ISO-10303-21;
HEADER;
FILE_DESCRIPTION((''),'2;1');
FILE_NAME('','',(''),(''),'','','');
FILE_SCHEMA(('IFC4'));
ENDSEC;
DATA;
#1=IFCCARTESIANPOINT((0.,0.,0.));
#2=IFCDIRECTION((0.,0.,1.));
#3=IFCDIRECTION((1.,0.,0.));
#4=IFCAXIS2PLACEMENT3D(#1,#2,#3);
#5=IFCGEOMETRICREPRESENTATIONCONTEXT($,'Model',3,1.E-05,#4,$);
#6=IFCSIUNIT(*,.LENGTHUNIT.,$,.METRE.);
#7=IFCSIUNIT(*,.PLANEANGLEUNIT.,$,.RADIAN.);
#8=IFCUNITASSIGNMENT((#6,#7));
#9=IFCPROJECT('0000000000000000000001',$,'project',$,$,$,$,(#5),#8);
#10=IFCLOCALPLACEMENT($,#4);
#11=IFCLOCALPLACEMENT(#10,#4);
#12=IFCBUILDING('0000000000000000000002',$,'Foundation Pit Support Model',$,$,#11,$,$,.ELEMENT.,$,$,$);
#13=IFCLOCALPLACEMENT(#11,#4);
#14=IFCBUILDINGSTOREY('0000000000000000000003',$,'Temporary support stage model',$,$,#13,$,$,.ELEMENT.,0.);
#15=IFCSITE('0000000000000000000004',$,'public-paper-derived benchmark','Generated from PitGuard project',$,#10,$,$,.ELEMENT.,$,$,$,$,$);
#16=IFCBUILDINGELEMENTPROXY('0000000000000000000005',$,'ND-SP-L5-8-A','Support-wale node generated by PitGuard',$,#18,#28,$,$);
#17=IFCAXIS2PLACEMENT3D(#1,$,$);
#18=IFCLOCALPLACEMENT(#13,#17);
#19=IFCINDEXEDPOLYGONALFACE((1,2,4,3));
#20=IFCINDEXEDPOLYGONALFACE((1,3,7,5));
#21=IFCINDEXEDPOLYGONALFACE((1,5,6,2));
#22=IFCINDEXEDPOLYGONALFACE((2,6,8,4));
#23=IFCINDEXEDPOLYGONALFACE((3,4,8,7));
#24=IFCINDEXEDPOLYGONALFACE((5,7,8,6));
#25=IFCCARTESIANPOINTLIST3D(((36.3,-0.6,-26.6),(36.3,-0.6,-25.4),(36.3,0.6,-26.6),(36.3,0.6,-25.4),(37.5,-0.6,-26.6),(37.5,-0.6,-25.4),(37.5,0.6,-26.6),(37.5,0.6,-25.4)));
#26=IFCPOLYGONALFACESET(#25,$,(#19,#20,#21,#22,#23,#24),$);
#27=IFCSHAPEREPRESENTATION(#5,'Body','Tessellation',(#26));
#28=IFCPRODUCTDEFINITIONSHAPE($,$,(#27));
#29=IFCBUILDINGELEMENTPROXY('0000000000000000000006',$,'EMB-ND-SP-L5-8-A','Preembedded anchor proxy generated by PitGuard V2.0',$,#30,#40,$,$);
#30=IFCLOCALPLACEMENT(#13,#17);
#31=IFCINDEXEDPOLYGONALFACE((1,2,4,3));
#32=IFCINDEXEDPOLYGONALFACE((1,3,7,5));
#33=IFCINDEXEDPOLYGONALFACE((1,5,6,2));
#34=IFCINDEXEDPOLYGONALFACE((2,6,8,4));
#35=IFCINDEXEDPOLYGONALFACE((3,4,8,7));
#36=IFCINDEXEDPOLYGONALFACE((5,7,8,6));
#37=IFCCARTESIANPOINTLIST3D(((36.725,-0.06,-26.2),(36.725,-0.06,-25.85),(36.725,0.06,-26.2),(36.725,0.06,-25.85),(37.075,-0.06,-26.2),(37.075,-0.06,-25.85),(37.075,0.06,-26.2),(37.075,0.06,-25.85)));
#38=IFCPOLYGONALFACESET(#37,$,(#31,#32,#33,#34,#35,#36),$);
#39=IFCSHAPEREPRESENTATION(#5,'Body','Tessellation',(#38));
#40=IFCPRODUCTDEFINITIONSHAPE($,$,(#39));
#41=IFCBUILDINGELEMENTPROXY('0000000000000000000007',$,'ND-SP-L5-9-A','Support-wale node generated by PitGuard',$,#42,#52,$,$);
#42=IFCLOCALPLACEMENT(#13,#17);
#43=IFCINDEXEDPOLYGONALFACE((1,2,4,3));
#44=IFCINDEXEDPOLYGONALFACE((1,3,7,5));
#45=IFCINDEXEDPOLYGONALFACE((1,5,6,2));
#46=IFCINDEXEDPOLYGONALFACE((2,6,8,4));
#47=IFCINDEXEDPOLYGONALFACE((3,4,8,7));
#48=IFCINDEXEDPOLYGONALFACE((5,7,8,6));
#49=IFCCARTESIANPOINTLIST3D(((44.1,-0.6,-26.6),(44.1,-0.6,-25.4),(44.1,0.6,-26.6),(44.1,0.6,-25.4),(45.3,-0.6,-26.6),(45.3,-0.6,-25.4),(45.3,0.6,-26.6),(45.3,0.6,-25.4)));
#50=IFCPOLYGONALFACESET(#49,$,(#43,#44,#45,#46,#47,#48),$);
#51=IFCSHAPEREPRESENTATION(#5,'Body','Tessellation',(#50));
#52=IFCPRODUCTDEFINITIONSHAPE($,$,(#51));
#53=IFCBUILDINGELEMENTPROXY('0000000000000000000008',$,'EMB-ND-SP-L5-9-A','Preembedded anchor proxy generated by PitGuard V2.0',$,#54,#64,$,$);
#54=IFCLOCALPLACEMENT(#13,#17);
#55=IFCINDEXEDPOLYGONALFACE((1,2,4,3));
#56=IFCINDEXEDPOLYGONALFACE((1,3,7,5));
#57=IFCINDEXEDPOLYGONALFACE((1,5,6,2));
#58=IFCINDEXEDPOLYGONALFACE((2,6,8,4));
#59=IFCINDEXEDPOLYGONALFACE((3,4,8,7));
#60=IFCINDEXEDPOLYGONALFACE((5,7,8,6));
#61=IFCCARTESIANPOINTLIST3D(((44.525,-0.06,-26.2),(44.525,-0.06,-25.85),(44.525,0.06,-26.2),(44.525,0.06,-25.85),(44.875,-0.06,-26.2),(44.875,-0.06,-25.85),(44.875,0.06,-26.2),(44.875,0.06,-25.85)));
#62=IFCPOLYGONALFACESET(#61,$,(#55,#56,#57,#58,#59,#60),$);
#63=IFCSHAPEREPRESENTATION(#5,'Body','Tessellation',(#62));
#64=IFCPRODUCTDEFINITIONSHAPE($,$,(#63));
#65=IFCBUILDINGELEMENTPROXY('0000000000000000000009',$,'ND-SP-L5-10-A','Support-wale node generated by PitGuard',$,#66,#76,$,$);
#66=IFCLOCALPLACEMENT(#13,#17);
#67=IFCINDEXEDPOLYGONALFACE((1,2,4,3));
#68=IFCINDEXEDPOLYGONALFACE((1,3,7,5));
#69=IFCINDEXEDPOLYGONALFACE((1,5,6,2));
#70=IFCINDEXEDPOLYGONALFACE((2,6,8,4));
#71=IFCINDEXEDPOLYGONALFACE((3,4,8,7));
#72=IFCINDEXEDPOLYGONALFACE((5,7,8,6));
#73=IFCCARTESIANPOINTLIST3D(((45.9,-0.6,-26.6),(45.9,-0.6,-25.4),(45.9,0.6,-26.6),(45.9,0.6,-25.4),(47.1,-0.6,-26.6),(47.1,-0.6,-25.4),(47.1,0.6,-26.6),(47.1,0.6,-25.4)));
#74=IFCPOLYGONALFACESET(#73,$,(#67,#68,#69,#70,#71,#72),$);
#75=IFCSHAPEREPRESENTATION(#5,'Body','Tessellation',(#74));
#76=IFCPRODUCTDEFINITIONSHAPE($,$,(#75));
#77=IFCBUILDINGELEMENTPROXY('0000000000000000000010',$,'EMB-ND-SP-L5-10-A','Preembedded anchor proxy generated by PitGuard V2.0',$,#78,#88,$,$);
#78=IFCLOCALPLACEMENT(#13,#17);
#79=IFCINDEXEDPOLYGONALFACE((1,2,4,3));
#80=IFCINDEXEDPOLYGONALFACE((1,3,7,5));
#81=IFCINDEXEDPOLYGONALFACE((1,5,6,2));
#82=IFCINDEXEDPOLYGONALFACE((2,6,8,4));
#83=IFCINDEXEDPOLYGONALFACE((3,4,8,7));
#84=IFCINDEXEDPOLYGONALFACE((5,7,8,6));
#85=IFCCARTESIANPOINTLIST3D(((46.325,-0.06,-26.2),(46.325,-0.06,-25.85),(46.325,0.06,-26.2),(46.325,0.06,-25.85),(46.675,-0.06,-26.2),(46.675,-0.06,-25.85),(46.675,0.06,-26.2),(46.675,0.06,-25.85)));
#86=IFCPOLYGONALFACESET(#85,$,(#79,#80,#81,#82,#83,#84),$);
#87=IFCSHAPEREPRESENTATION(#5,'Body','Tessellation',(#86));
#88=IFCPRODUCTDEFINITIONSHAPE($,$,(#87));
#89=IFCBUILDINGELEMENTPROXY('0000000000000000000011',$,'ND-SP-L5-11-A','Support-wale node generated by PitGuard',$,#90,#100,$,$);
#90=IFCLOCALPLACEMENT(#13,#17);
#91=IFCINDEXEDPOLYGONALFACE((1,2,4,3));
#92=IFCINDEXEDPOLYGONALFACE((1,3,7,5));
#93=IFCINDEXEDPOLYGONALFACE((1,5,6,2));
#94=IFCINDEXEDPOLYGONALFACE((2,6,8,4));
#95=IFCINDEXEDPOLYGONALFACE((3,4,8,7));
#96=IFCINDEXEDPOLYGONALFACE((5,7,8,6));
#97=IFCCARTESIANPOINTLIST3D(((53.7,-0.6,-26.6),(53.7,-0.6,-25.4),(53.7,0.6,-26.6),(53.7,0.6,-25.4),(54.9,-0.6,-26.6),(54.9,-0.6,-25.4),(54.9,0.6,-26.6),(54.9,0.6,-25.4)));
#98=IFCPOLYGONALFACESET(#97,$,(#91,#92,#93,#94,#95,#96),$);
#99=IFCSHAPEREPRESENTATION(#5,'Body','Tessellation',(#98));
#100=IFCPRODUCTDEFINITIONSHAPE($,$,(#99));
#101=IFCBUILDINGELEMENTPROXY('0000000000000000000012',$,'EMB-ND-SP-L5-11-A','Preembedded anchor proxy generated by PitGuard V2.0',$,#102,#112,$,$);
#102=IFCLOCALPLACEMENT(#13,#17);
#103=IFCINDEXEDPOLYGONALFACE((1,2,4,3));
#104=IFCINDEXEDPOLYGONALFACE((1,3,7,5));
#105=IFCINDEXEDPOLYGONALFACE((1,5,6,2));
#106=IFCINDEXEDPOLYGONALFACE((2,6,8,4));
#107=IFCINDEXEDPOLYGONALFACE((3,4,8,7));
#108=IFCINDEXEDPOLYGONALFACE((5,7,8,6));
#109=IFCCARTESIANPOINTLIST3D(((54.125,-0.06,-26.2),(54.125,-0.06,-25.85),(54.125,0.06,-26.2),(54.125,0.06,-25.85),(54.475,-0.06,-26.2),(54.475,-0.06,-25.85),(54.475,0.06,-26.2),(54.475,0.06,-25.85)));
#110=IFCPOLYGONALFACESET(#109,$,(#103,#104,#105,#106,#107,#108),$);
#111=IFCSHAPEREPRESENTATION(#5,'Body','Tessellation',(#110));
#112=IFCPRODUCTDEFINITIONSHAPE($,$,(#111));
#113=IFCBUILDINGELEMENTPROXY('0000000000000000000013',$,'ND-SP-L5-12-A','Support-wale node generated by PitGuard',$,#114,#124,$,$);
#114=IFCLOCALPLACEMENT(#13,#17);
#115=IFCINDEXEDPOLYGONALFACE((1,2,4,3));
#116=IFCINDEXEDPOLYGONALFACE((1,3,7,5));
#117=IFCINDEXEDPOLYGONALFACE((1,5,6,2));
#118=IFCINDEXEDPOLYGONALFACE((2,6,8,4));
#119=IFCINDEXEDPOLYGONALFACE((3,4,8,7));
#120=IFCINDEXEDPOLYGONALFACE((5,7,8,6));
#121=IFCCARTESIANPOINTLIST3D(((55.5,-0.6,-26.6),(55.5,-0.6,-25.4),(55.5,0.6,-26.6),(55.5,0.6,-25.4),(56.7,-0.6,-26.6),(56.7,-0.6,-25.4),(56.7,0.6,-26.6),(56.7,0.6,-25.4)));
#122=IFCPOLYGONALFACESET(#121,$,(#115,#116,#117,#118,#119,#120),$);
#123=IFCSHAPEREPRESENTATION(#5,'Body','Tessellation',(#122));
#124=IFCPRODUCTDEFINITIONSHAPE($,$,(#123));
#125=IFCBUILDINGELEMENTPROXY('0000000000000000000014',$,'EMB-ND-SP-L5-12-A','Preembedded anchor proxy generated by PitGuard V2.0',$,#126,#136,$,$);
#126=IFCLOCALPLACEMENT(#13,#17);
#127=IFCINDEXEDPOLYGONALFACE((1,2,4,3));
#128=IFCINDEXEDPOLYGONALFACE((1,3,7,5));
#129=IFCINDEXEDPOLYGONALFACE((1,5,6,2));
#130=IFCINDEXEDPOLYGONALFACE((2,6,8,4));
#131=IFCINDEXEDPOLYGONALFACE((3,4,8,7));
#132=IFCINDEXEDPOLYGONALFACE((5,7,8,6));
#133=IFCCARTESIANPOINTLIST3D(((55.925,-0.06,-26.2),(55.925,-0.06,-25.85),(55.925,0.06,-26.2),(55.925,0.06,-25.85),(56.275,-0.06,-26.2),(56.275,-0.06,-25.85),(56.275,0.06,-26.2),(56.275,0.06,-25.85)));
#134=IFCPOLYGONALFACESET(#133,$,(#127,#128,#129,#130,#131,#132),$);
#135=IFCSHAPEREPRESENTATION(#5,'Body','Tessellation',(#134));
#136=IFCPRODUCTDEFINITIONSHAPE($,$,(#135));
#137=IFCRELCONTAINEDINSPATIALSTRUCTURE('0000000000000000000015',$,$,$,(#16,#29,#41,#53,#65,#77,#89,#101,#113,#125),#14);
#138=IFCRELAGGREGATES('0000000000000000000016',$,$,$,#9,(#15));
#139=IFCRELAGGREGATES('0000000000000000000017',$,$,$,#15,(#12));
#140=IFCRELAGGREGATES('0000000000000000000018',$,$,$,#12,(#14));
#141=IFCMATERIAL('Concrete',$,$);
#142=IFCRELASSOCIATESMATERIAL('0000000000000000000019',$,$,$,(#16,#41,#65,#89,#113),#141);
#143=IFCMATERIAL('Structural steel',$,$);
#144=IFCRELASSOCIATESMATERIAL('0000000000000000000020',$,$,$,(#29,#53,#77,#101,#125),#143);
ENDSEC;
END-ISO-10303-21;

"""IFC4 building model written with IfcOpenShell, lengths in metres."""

from ifc_helpers import new_model, si_unit, frame, origin_with_axes, origin_2d, place, context, project, spatial, rectangle, extrude, material, element, save


model = new_model("IFC4")

# Units and contexts
model_context = context("Model", 3, precision=1e-05, world=origin_with_axes())
ifc_project = project(units=[si_unit("LENGTHUNIT", "METRE"), si_unit("PLANEANGLEUNIT", "RADIAN")], contexts=[model_context])

# Site, building, storey
site_placement = place(None, origin_with_axes())
site = spatial("IfcSite", under=ifc_project, at=site_placement, Name="public-paper-derived benchmark", Description="Generated from PitGuard project", CompositionType="ELEMENT")
building_placement = place(site_placement, origin_with_axes())
building = spatial("IfcBuilding", under=site, at=building_placement, Name="Foundation Pit Support Model", CompositionType="ELEMENT")
storey_placement = place(building_placement, origin_with_axes())
storey = spatial("IfcBuildingStorey", under=building, at=storey_placement, Name="Temporary support stage model", CompositionType="ELEMENT", Elevation=0.0)

# Shared definitions
ifc_material_1 = material(Name="Structural steel")

# Shared definitions
ifc_material_2 = material(Name="Concrete")

# Building element proxies
proxy_1_placement = place(storey_placement, frame((36.9, 0.0, -26.6), z_axis=(0.0, 0.0, 1.0), x_axis=(1.0, 0.0, 0.0)))
element("IfcBuildingElementProxy", 1, at=proxy_1_placement, inside=storey, material=ifc_material_2, Name="ND-SP-L5-8-A", Description="Support-wale node generated by PitGuard", context=model_context, shape_type="SweptSolid", body=[
    extrude(rectangle(XDim=1.2, YDim=1.2, at=origin_2d()), origin_with_axes(), (0.0, 0.0, 1.0), 1.2),
])
proxy_2_placement = place(storey_placement, frame((36.9, 0.0, -26.2), z_axis=(0.0, 0.0, 1.0), x_axis=(1.0, 0.0, 0.0)))
element("IfcBuildingElementProxy", 2, at=proxy_2_placement, inside=storey, material=ifc_material_1, Name="EMB-ND-SP-L5-8-A", Description="Preembedded anchor proxy generated by PitGuard V2.0", context=model_context, shape_type="SweptSolid", body=[
    extrude(rectangle(XDim=0.35, YDim=0.12, at=origin_2d()), origin_with_axes(), (0.0, 0.0, 1.0), 0.35),
])
proxy_3_placement = place(storey_placement, frame((44.7, 0.0, -26.6), z_axis=(0.0, 0.0, 1.0), x_axis=(1.0, 0.0, 0.0)))
element("IfcBuildingElementProxy", 3, at=proxy_3_placement, inside=storey, material=ifc_material_2, Name="ND-SP-L5-9-A", Description="Support-wale node generated by PitGuard", context=model_context, shape_type="SweptSolid", body=[
    extrude(rectangle(XDim=1.2, YDim=1.2, at=origin_2d()), origin_with_axes(), (0.0, 0.0, 1.0), 1.2),
])
proxy_4_placement = place(storey_placement, frame((44.7, 0.0, -26.2), z_axis=(0.0, 0.0, 1.0), x_axis=(1.0, 0.0, 0.0)))
element("IfcBuildingElementProxy", 4, at=proxy_4_placement, inside=storey, material=ifc_material_1, Name="EMB-ND-SP-L5-9-A", Description="Preembedded anchor proxy generated by PitGuard V2.0", context=model_context, shape_type="SweptSolid", body=[
    extrude(rectangle(XDim=0.35, YDim=0.12, at=origin_2d()), origin_with_axes(), (0.0, 0.0, 1.0), 0.35),
])
proxy_5_placement = place(storey_placement, frame((46.5, 0.0, -26.6), z_axis=(0.0, 0.0, 1.0), x_axis=(1.0, 0.0, 0.0)))
element("IfcBuildingElementProxy", 5, at=proxy_5_placement, inside=storey, material=ifc_material_2, Name="ND-SP-L5-10-A", Description="Support-wale node generated by PitGuard", context=model_context, shape_type="SweptSolid", body=[
    extrude(rectangle(XDim=1.2, YDim=1.2, at=origin_2d()), origin_with_axes(), (0.0, 0.0, 1.0), 1.2),
])
proxy_6_placement = place(storey_placement, frame((46.5, 0.0, -26.2), z_axis=(0.0, 0.0, 1.0), x_axis=(1.0, 0.0, 0.0)))
element("IfcBuildingElementProxy", 6, at=proxy_6_placement, inside=storey, material=ifc_material_1, Name="EMB-ND-SP-L5-10-A", Description="Preembedded anchor proxy generated by PitGuard V2.0", context=model_context, shape_type="SweptSolid", body=[
    extrude(rectangle(XDim=0.35, YDim=0.12, at=origin_2d()), origin_with_axes(), (0.0, 0.0, 1.0), 0.35),
])
proxy_7_placement = place(storey_placement, frame((54.3, 0.0, -26.6), z_axis=(0.0, 0.0, 1.0), x_axis=(1.0, 0.0, 0.0)))
element("IfcBuildingElementProxy", 7, at=proxy_7_placement, inside=storey, material=ifc_material_2, Name="ND-SP-L5-11-A", Description="Support-wale node generated by PitGuard", context=model_context, shape_type="SweptSolid", body=[
    extrude(rectangle(XDim=1.2, YDim=1.2, at=origin_2d()), origin_with_axes(), (0.0, 0.0, 1.0), 1.2),
])
proxy_8_placement = place(storey_placement, frame((54.3, 0.0, -26.2), z_axis=(0.0, 0.0, 1.0), x_axis=(1.0, 0.0, 0.0)))
element("IfcBuildingElementProxy", 8, at=proxy_8_placement, inside=storey, material=ifc_material_1, Name="EMB-ND-SP-L5-11-A", Description="Preembedded anchor proxy generated by PitGuard V2.0", context=model_context, shape_type="SweptSolid", body=[
    extrude(rectangle(XDim=0.35, YDim=0.12, at=origin_2d()), origin_with_axes(), (0.0, 0.0, 1.0), 0.35),
])
proxy_9_placement = place(storey_placement, frame((56.1, 0.0, -26.6), z_axis=(0.0, 0.0, 1.0), x_axis=(1.0, 0.0, 0.0)))
element("IfcBuildingElementProxy", 9, at=proxy_9_placement, inside=storey, material=ifc_material_2, Name="ND-SP-L5-12-A", Description="Support-wale node generated by PitGuard", context=model_context, shape_type="SweptSolid", body=[
    extrude(rectangle(XDim=1.2, YDim=1.2, at=origin_2d()), origin_with_axes(), (0.0, 0.0, 1.0), 1.2),
])
proxy_10_placement = place(storey_placement, frame((56.1, 0.0, -26.2), z_axis=(0.0, 0.0, 1.0), x_axis=(1.0, 0.0, 0.0)))
element("IfcBuildingElementProxy", 10, at=proxy_10_placement, inside=storey, material=ifc_material_1, Name="EMB-ND-SP-L5-12-A", Description="Preembedded anchor proxy generated by PitGuard V2.0", context=model_context, shape_type="SweptSolid", body=[
    extrude(rectangle(XDim=0.35, YDim=0.12, at=origin_2d()), origin_with_axes(), (0.0, 0.0, 1.0), 0.35),
])

save(model, "model.ifc")
